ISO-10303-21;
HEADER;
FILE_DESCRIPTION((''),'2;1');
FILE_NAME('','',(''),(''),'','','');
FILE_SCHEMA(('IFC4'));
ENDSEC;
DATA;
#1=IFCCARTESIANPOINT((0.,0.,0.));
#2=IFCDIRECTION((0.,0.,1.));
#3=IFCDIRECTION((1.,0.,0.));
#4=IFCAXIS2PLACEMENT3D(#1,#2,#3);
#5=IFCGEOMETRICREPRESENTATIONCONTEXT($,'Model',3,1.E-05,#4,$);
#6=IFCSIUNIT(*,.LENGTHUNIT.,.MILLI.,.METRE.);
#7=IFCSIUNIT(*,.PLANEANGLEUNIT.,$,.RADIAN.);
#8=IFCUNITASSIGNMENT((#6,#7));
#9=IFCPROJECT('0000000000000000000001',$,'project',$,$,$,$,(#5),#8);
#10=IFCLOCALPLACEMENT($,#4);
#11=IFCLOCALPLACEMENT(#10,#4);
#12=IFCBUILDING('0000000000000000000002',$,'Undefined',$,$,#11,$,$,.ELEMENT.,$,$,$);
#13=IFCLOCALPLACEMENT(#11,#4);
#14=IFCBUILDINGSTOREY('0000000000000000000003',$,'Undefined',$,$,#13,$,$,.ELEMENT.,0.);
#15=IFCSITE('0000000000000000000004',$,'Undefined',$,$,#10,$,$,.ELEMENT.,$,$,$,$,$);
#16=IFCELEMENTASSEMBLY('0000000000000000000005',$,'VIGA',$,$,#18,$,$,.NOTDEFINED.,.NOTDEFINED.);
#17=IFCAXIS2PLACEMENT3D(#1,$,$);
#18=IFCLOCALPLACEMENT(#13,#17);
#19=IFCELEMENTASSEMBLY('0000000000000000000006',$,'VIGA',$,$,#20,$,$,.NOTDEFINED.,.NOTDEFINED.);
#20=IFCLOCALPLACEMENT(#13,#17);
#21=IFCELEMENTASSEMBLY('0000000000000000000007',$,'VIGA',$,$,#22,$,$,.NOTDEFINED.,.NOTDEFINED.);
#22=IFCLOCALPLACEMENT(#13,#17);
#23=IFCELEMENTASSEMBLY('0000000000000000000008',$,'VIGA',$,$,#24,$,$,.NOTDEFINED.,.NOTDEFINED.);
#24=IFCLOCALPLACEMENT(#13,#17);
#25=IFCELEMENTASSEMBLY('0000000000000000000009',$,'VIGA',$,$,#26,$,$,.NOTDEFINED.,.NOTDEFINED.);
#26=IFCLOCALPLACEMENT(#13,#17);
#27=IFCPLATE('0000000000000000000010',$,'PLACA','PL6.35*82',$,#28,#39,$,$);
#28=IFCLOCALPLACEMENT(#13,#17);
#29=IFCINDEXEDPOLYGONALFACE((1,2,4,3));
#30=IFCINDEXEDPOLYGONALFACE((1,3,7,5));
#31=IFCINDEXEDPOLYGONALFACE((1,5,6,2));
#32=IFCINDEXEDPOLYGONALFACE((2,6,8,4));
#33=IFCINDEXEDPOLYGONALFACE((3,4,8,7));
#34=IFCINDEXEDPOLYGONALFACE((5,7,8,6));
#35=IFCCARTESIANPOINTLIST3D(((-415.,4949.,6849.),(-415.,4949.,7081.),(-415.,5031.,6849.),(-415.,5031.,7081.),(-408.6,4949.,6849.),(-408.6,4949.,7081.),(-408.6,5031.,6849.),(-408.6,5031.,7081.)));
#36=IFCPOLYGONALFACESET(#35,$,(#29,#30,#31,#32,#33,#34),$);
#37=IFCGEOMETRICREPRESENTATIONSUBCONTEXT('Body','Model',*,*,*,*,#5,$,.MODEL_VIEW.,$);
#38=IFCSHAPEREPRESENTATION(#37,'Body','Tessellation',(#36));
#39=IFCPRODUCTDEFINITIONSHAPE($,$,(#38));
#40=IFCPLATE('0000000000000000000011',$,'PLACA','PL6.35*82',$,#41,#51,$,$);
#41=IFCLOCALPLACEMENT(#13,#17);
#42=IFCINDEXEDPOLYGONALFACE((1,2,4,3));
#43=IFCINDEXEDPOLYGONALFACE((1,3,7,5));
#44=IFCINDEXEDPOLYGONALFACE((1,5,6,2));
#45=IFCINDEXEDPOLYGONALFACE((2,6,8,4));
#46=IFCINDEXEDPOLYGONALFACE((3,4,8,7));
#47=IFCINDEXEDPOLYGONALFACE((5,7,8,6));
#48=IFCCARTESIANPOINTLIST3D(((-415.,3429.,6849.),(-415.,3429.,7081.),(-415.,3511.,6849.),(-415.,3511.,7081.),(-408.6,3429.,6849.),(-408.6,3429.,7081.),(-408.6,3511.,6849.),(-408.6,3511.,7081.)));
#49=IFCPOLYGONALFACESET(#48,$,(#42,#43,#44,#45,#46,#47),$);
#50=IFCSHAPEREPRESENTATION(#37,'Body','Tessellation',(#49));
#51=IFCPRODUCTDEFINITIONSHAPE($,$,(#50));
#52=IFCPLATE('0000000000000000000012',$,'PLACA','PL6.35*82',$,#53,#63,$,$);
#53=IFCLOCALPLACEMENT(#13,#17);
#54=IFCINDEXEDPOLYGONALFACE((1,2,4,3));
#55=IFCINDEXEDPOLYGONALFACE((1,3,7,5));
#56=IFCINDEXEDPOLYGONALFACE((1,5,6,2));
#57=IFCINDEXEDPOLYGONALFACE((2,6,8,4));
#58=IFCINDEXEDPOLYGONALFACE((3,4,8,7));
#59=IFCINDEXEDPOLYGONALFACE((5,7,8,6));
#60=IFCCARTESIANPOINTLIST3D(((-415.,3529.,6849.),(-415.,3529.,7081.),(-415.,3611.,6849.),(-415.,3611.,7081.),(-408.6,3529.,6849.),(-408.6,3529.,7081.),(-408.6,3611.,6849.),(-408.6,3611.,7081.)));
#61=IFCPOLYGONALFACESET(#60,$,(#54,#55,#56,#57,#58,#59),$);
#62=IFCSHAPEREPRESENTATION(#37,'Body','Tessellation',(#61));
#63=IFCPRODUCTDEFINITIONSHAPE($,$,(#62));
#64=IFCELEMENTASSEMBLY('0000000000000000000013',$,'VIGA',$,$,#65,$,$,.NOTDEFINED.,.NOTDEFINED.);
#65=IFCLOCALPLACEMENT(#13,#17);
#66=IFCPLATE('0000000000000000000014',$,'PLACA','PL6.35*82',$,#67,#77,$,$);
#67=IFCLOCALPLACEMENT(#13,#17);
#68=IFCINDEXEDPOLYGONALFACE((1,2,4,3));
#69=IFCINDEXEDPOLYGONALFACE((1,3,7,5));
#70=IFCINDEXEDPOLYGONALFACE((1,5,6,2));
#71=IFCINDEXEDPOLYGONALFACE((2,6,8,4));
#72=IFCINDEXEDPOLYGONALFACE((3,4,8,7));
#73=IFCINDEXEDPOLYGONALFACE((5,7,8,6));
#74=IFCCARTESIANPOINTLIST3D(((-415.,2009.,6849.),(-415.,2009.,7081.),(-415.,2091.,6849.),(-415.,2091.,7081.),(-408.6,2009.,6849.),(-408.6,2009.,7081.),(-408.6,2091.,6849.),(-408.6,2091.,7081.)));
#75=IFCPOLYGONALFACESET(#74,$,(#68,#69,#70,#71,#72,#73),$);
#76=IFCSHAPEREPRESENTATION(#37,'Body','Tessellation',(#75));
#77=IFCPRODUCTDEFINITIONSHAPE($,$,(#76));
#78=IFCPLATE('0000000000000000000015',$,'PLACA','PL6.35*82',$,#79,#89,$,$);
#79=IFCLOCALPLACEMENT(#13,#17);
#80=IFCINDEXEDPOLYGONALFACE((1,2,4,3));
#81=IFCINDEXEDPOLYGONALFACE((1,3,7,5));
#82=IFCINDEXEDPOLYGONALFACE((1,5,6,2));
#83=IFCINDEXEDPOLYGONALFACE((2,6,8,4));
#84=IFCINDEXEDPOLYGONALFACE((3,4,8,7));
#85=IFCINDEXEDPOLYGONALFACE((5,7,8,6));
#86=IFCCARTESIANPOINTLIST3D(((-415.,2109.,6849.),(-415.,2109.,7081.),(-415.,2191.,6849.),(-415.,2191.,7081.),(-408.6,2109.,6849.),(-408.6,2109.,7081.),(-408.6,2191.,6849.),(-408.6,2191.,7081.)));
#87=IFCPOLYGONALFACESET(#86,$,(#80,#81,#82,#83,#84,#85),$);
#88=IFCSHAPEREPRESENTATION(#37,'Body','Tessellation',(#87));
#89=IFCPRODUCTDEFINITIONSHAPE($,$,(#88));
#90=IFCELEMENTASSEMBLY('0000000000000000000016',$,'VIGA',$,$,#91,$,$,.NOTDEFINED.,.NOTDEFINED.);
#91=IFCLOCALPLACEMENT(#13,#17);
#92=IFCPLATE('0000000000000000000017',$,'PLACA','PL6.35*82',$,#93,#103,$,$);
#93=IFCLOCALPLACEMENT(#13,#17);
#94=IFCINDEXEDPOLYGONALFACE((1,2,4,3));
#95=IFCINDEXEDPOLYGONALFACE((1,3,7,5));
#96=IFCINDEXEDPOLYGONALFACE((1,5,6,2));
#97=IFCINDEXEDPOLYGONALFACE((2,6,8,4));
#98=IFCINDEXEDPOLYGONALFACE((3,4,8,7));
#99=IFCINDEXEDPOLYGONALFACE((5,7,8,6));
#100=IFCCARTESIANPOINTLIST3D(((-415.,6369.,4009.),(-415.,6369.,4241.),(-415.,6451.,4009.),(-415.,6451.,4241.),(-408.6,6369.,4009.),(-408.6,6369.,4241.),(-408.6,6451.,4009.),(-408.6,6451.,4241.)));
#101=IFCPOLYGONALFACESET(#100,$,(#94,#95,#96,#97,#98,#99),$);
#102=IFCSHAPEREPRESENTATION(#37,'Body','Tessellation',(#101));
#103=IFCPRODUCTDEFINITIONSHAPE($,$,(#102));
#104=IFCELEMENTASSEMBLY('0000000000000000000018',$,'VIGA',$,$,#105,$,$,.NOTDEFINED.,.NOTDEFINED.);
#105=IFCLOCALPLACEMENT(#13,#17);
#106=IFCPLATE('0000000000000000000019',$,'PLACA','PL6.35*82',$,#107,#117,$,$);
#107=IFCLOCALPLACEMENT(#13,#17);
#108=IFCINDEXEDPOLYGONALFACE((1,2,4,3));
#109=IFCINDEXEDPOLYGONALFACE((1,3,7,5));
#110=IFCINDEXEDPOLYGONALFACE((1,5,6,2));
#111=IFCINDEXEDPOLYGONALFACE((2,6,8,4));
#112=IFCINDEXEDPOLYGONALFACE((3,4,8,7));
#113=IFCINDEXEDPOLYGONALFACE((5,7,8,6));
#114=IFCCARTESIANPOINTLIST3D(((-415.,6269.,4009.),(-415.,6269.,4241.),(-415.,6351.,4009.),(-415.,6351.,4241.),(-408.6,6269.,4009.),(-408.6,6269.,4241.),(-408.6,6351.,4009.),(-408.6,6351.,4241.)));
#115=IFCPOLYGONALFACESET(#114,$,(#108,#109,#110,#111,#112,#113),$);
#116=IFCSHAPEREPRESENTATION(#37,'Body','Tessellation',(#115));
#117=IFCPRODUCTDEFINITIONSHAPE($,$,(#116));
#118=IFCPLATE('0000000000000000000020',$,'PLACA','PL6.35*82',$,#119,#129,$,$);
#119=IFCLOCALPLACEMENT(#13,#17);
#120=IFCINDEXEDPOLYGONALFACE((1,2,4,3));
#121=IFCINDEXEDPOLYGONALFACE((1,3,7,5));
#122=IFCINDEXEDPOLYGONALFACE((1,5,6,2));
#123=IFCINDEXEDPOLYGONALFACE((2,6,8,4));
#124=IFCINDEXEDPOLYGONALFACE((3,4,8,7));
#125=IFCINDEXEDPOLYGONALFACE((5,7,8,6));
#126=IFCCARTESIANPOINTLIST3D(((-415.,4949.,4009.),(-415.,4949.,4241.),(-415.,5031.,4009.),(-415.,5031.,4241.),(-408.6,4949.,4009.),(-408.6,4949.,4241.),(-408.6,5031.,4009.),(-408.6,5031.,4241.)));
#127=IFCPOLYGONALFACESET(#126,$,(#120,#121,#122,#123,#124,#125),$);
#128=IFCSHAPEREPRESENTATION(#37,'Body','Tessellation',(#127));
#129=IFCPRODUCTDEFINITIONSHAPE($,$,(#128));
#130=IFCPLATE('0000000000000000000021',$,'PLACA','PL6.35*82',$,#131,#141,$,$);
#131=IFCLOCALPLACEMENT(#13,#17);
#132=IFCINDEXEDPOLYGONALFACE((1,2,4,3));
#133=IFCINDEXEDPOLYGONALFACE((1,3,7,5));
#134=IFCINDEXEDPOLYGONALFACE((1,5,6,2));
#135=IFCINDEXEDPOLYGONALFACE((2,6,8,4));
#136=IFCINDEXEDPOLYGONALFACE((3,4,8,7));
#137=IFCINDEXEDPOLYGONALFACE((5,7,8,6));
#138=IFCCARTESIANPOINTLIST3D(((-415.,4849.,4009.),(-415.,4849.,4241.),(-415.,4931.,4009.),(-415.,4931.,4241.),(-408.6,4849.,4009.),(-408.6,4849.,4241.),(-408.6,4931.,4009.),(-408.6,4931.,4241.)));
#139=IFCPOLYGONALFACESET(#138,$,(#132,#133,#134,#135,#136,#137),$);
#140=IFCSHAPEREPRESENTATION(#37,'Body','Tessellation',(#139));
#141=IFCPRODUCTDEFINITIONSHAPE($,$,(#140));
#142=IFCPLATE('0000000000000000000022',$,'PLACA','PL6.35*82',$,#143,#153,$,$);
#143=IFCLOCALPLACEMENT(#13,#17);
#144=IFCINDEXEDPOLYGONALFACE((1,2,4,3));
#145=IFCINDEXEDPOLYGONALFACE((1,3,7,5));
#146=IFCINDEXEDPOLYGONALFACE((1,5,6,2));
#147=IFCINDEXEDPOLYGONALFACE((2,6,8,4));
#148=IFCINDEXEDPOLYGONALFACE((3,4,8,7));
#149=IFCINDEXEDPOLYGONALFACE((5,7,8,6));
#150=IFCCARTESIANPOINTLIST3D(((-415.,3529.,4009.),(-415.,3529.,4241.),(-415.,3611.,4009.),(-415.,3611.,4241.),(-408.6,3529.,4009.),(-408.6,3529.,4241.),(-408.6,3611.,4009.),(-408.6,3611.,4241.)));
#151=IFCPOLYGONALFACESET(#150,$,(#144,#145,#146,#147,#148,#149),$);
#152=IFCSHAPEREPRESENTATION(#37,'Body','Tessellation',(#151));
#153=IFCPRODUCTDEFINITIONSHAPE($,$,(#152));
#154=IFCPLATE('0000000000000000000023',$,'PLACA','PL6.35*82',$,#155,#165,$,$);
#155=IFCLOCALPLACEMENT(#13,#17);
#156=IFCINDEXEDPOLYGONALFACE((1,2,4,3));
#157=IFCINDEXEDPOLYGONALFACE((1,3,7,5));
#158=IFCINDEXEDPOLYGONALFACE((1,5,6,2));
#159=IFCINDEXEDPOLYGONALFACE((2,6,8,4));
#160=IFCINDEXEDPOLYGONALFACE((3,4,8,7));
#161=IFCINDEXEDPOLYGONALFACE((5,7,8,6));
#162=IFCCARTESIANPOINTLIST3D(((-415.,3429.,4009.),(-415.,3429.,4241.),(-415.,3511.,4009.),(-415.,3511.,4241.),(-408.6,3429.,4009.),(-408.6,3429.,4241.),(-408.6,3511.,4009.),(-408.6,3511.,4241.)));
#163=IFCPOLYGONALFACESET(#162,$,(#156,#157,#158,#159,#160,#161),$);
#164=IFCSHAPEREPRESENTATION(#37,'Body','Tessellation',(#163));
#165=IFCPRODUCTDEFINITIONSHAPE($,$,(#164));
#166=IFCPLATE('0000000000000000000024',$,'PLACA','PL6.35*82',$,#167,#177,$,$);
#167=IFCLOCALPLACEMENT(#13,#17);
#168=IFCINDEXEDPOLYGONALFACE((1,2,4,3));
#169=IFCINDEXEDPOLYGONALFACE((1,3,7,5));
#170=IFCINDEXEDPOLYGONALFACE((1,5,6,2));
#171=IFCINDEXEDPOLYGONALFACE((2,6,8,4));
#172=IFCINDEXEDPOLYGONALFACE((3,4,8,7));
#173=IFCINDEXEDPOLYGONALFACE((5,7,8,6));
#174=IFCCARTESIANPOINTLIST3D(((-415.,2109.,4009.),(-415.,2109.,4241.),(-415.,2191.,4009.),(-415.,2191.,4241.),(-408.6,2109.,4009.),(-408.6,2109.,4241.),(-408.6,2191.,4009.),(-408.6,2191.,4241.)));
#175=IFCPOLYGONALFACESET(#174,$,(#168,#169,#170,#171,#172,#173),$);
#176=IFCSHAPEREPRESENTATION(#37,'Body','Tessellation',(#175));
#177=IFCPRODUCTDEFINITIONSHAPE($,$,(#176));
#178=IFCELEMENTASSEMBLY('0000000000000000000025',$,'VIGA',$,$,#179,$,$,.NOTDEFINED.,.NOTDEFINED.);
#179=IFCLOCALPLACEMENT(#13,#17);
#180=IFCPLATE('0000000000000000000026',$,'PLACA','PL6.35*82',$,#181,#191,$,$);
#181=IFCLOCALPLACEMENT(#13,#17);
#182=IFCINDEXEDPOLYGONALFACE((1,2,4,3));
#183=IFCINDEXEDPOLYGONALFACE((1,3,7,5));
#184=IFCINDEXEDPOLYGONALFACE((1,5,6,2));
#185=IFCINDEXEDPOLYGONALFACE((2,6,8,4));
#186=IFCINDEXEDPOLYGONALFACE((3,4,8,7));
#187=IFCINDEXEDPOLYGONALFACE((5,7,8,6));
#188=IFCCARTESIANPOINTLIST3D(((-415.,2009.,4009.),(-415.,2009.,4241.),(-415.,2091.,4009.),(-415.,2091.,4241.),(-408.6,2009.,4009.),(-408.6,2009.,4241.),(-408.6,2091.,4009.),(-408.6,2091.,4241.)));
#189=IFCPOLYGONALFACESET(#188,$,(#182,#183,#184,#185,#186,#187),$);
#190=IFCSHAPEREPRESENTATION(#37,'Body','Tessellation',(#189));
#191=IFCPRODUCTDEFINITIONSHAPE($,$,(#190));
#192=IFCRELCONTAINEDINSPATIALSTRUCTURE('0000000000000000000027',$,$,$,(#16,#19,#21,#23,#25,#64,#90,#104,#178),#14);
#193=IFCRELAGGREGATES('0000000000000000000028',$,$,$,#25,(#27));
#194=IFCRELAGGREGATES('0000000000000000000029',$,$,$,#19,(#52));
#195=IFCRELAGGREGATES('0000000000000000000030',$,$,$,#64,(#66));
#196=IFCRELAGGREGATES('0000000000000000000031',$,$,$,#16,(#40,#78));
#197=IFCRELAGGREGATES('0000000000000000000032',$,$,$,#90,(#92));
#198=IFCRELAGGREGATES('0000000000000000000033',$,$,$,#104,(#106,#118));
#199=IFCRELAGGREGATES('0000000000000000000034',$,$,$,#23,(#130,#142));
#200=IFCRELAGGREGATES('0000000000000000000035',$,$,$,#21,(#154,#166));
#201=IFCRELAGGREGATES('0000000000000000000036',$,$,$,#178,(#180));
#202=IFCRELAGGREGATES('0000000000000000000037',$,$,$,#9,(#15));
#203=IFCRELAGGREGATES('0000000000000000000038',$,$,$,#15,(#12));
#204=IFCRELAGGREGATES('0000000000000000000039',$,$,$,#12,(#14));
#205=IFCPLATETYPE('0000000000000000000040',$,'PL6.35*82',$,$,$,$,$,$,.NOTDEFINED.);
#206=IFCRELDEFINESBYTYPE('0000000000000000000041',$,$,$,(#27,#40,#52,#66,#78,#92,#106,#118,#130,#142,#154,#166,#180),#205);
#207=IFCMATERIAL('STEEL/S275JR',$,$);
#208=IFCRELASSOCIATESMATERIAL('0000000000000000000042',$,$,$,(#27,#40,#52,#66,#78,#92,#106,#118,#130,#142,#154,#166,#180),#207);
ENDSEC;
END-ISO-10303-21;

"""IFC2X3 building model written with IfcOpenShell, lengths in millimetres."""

from ifc_helpers import new_model, si_unit, frame, origin_with_axes, place, context, subcontext, project, spatial, polyline, outline, extrude, material, type_object, element, aggregate, save


model = new_model("IFC2X3")

# Units and contexts
model_context = context("Model", 3, precision=1e-05, world=origin_with_axes())
body_context = subcontext(model_context, "Body", "Model", "MODEL_VIEW")
ifc_project = project(units=[si_unit("LENGTHUNIT", "METRE", prefix="MILLI"), si_unit("PLANEANGLEUNIT", "RADIAN")], contexts=[model_context])

# Site, building, storey
site_placement = place(None, origin_with_axes())
site = spatial("IfcSite", under=ifc_project, at=site_placement, Name="Undefined", CompositionType="ELEMENT")
building_placement = place(site_placement, origin_with_axes())
building = spatial("IfcBuilding", under=site, at=building_placement, Name="Undefined", CompositionType="ELEMENT")
storey_placement = place(building_placement, origin_with_axes())
storey = spatial("IfcBuildingStorey", under=building, at=storey_placement, Name="Undefined", CompositionType="ELEMENT", Elevation=0.0)

# Element assemblies
assembly_1_placement = place(storey_placement, origin_with_axes())
assembly_1 = element("IfcElementAssembly", 1, at=assembly_1_placement, inside=storey, Name="VIGA", AssemblyPlace="NOTDEFINED", PredefinedType="NOTDEFINED")
ifc_material_1 = material(Name="STEEL/S275JR")
assembly_2_placement = place(storey_placement, origin_with_axes())
assembly_2 = element("IfcElementAssembly", 2, at=assembly_2_placement, inside=storey, Name="VIGA", AssemblyPlace="NOTDEFINED", PredefinedType="NOTDEFINED")
assembly_3_placement = place(storey_placement, origin_with_axes())
assembly_3 = element("IfcElementAssembly", 3, at=assembly_3_placement, inside=storey, Name="VIGA", AssemblyPlace="NOTDEFINED", PredefinedType="NOTDEFINED")
assembly_4_placement = place(storey_placement, origin_with_axes())
assembly_4 = element("IfcElementAssembly", 4, at=assembly_4_placement, inside=storey, Name="VIGA", AssemblyPlace="NOTDEFINED", PredefinedType="NOTDEFINED")
assembly_5_placement = place(storey_placement, origin_with_axes())
assembly_5 = element("IfcElementAssembly", 5, at=assembly_5_placement, inside=storey, Name="VIGA", AssemblyPlace="NOTDEFINED", PredefinedType="NOTDEFINED")
plate_type_1 = type_object("IfcPlateType", Name="PL6.35*82", PredefinedType="NOTDEFINED")

# Plates
plate_1_placement = place(assembly_5_placement, frame((-411.8, 4949.0, 7081.0), z_axis=(-1.0, 0.0, 0.0), x_axis=(0.0, 1.0, 0.0)))
plate_1 = element("IfcPlate", 6, at=plate_1_placement, type_object=plate_type_1, material=ifc_material_1, Name="PLACA", Description="PL6.35*82", context=body_context, shape_type="SweptSolid", body=[
    extrude(outline(polyline([(0.0, 0.0), (82.0, 0.0), (82.0, 232.0), (0.0, 232.0), (0.0, 0.0)])), frame((0.0, 0.0, -3.2), z_axis=(0.0, 0.0, 1.0), x_axis=(1.0, 0.0, 0.0)), (0.0, 0.0, 1.0), 6.4),
])
aggregate(assembly_5, [plate_1])
plate_2_placement = place(assembly_1_placement, frame((-411.8, 3429.0, 7081.0), z_axis=(-1.0, 0.0, 0.0), x_axis=(0.0, 1.0, 0.0)))
plate_2 = element("IfcPlate", 7, at=plate_2_placement, type_object=plate_type_1, material=ifc_material_1, Name="PLACA", Description="PL6.35*82", context=body_context, shape_type="SweptSolid", body=[
    extrude(outline(polyline([(0.0, 0.0), (82.0, 0.0), (82.0, 232.0), (0.0, 232.0), (0.0, 0.0)])), frame((0.0, 0.0, -3.2), z_axis=(0.0, 0.0, 1.0), x_axis=(1.0, 0.0, 0.0)), (0.0, 0.0, 1.0), 6.4),
])
plate_3_placement = place(assembly_2_placement, frame((-411.8, 3529.0, 7081.0), z_axis=(-1.0, 0.0, 0.0), x_axis=(0.0, 1.0, 0.0)))
plate_3 = element("IfcPlate", 8, at=plate_3_placement, type_object=plate_type_1, material=ifc_material_1, Name="PLACA", Description="PL6.35*82", context=body_context, shape_type="SweptSolid", body=[
    extrude(outline(polyline([(0.0, 0.0), (82.0, 0.0), (82.0, 232.0), (0.0, 232.0), (0.0, 0.0)])), frame((0.0, 0.0, -3.2), z_axis=(0.0, 0.0, 1.0), x_axis=(1.0, 0.0, 0.0)), (0.0, 0.0, 1.0), 6.4),
])
aggregate(assembly_2, [plate_3])

# Element assembly, plate
assembly_6_placement = place(storey_placement, origin_with_axes())
assembly_6 = element("IfcElementAssembly", 9, at=assembly_6_placement, inside=storey, Name="VIGA", AssemblyPlace="NOTDEFINED", PredefinedType="NOTDEFINED")
plate_4_placement = place(assembly_6_placement, frame((-411.8, 2009.0, 7081.0), z_axis=(-1.0, 0.0, 0.0), x_axis=(0.0, 1.0, 0.0)))
plate_4 = element("IfcPlate", 10, at=plate_4_placement, type_object=plate_type_1, material=ifc_material_1, Name="PLACA", Description="PL6.35*82", context=body_context, shape_type="SweptSolid", body=[
    extrude(outline(polyline([(0.0, 0.0), (82.0, 0.0), (82.0, 232.0), (0.0, 232.0), (0.0, 0.0)])), frame((0.0, 0.0, -3.2), z_axis=(0.0, 0.0, 1.0), x_axis=(1.0, 0.0, 0.0)), (0.0, 0.0, 1.0), 6.4),
])
aggregate(assembly_6, [plate_4])

# Plate
plate_5_placement = place(assembly_1_placement, frame((-411.8, 2109.0, 7081.0), z_axis=(-1.0, 0.0, 0.0), x_axis=(0.0, 1.0, 0.0)))
plate_5 = element("IfcPlate", 11, at=plate_5_placement, type_object=plate_type_1, material=ifc_material_1, Name="PLACA", Description="PL6.35*82", context=body_context, shape_type="SweptSolid", body=[
    extrude(outline(polyline([(0.0, 0.0), (82.0, 0.0), (82.0, 232.0), (0.0, 232.0), (0.0, 0.0)])), frame((0.0, 0.0, -3.2), z_axis=(0.0, 0.0, 1.0), x_axis=(1.0, 0.0, 0.0)), (0.0, 0.0, 1.0), 6.4),
])
aggregate(assembly_1, [plate_2, plate_5])

# Element assembly, plate
assembly_7_placement = place(storey_placement, origin_with_axes())
assembly_7 = element("IfcElementAssembly", 12, at=assembly_7_placement, inside=storey, Name="VIGA", AssemblyPlace="NOTDEFINED", PredefinedType="NOTDEFINED")
plate_6_placement = place(assembly_7_placement, frame((-411.8, 6369.0, 4241.0), z_axis=(-1.0, 0.0, 0.0), x_axis=(0.0, 1.0, 0.0)))
plate_6 = element("IfcPlate", 13, at=plate_6_placement, type_object=plate_type_1, material=ifc_material_1, Name="PLACA", Description="PL6.35*82", context=body_context, shape_type="SweptSolid", body=[
    extrude(outline(polyline([(0.0, 0.0), (82.0, 0.0), (82.0, 232.0), (0.0, 232.0), (0.0, 0.0)])), frame((0.0, 0.0, -3.2), z_axis=(0.0, 0.0, 1.0), x_axis=(1.0, 0.0, 0.0)), (0.0, 0.0, 1.0), 6.4),
])
aggregate(assembly_7, [plate_6])

# Element assembly, plates
assembly_8_placement = place(storey_placement, origin_with_axes())
assembly_8 = element("IfcElementAssembly", 14, at=assembly_8_placement, inside=storey, Name="VIGA", AssemblyPlace="NOTDEFINED", PredefinedType="NOTDEFINED")
plate_7_placement = place(assembly_8_placement, frame((-411.8, 6269.0, 4241.0), z_axis=(-1.0, 0.0, 0.0), x_axis=(0.0, 1.0, 0.0)))
plate_7 = element("IfcPlate", 15, at=plate_7_placement, type_object=plate_type_1, material=ifc_material_1, Name="PLACA", Description="PL6.35*82", context=body_context, shape_type="SweptSolid", body=[
    extrude(outline(polyline([(0.0, 0.0), (82.0, 0.0), (82.0, 232.0), (0.0, 232.0), (0.0, 0.0)])), frame((0.0, 0.0, -3.2), z_axis=(0.0, 0.0, 1.0), x_axis=(1.0, 0.0, 0.0)), (0.0, 0.0, 1.0), 6.4),
])
plate_8_placement = place(assembly_8_placement, frame((-411.8, 4949.0, 4241.0), z_axis=(-1.0, 0.0, 0.0), x_axis=(0.0, 1.0, 0.0)))
plate_8 = element("IfcPlate", 16, at=plate_8_placement, type_object=plate_type_1, material=ifc_material_1, Name="PLACA", Description="PL6.35*82", context=body_context, shape_type="SweptSolid", body=[
    extrude(outline(polyline([(0.0, 0.0), (82.0, 0.0), (82.0, 232.0), (0.0, 232.0), (0.0, 0.0)])), frame((0.0, 0.0, -3.2), z_axis=(0.0, 0.0, 1.0), x_axis=(1.0, 0.0, 0.0)), (0.0, 0.0, 1.0), 6.4),
])
aggregate(assembly_8, [plate_7, plate_8])

# Plates
plate_9_placement = place(assembly_4_placement, frame((-411.8, 4849.0, 4241.0), z_axis=(-1.0, 0.0, 0.0), x_axis=(0.0, 1.0, 0.0)))
plate_9 = element("IfcPlate", 17, at=plate_9_placement, type_object=plate_type_1, material=ifc_material_1, Name="PLACA", Description="PL6.35*82", context=body_context, shape_type="SweptSolid", body=[
    extrude(outline(polyline([(0.0, 0.0), (82.0, 0.0), (82.0, 232.0), (0.0, 232.0), (0.0, 0.0)])), frame((0.0, 0.0, -3.2), z_axis=(0.0, 0.0, 1.0), x_axis=(1.0, 0.0, 0.0)), (0.0, 0.0, 1.0), 6.4),
])
plate_10_placement = place(assembly_4_placement, frame((-411.8, 3529.0, 4241.0), z_axis=(-1.0, 0.0, 0.0), x_axis=(0.0, 1.0, 0.0)))
plate_10 = element("IfcPlate", 18, at=plate_10_placement, type_object=plate_type_1, material=ifc_material_1, Name="PLACA", Description="PL6.35*82", context=body_context, shape_type="SweptSolid", body=[
    extrude(outline(polyline([(0.0, 0.0), (82.0, 0.0), (82.0, 232.0), (0.0, 232.0), (0.0, 0.0)])), frame((0.0, 0.0, -3.2), z_axis=(0.0, 0.0, 1.0), x_axis=(1.0, 0.0, 0.0)), (0.0, 0.0, 1.0), 6.4),
])
aggregate(assembly_4, [plate_9, plate_10])
plate_11_placement = place(assembly_3_placement, frame((-411.8, 3429.0, 4241.0), z_axis=(-1.0, 0.0, 0.0), x_axis=(0.0, 1.0, 0.0)))
plate_11 = element("IfcPlate", 19, at=plate_11_placement, type_object=plate_type_1, material=ifc_material_1, Name="PLACA", Description="PL6.35*82", context=body_context, shape_type="SweptSolid", body=[
    extrude(outline(polyline([(0.0, 0.0), (82.0, 0.0), (82.0, 232.0), (0.0, 232.0), (0.0, 0.0)])), frame((0.0, 0.0, -3.2), z_axis=(0.0, 0.0, 1.0), x_axis=(1.0, 0.0, 0.0)), (0.0, 0.0, 1.0), 6.4),
])
plate_12_placement = place(assembly_3_placement, frame((-411.8, 2109.0, 4241.0), z_axis=(-1.0, 0.0, 0.0), x_axis=(0.0, 1.0, 0.0)))
plate_12 = element("IfcPlate", 20, at=plate_12_placement, type_object=plate_type_1, material=ifc_material_1, Name="PLACA", Description="PL6.35*82", context=body_context, shape_type="SweptSolid", body=[
    extrude(outline(polyline([(0.0, 0.0), (82.0, 0.0), (82.0, 232.0), (0.0, 232.0), (0.0, 0.0)])), frame((0.0, 0.0, -3.2), z_axis=(0.0, 0.0, 1.0), x_axis=(1.0, 0.0, 0.0)), (0.0, 0.0, 1.0), 6.4),
])
aggregate(assembly_3, [plate_11, plate_12])

# Element assembly, plate
assembly_9_placement = place(storey_placement, origin_with_axes())
assembly_9 = element("IfcElementAssembly", 21, at=assembly_9_placement, inside=storey, Name="VIGA", AssemblyPlace="NOTDEFINED", PredefinedType="NOTDEFINED")
plate_13_placement = place(assembly_9_placement, frame((-411.8, 2009.0, 4241.0), z_axis=(-1.0, 0.0, 0.0), x_axis=(0.0, 1.0, 0.0)))
plate_13 = element("IfcPlate", 22, at=plate_13_placement, type_object=plate_type_1, material=ifc_material_1, Name="PLACA", Description="PL6.35*82", context=body_context, shape_type="SweptSolid", body=[
    extrude(outline(polyline([(0.0, 0.0), (82.0, 0.0), (82.0, 232.0), (0.0, 232.0), (0.0, 0.0)])), frame((0.0, 0.0, -3.2), z_axis=(0.0, 0.0, 1.0), x_axis=(1.0, 0.0, 0.0)), (0.0, 0.0, 1.0), 6.4),
])
aggregate(assembly_9, [plate_13])

save(model, "model.ifc")
